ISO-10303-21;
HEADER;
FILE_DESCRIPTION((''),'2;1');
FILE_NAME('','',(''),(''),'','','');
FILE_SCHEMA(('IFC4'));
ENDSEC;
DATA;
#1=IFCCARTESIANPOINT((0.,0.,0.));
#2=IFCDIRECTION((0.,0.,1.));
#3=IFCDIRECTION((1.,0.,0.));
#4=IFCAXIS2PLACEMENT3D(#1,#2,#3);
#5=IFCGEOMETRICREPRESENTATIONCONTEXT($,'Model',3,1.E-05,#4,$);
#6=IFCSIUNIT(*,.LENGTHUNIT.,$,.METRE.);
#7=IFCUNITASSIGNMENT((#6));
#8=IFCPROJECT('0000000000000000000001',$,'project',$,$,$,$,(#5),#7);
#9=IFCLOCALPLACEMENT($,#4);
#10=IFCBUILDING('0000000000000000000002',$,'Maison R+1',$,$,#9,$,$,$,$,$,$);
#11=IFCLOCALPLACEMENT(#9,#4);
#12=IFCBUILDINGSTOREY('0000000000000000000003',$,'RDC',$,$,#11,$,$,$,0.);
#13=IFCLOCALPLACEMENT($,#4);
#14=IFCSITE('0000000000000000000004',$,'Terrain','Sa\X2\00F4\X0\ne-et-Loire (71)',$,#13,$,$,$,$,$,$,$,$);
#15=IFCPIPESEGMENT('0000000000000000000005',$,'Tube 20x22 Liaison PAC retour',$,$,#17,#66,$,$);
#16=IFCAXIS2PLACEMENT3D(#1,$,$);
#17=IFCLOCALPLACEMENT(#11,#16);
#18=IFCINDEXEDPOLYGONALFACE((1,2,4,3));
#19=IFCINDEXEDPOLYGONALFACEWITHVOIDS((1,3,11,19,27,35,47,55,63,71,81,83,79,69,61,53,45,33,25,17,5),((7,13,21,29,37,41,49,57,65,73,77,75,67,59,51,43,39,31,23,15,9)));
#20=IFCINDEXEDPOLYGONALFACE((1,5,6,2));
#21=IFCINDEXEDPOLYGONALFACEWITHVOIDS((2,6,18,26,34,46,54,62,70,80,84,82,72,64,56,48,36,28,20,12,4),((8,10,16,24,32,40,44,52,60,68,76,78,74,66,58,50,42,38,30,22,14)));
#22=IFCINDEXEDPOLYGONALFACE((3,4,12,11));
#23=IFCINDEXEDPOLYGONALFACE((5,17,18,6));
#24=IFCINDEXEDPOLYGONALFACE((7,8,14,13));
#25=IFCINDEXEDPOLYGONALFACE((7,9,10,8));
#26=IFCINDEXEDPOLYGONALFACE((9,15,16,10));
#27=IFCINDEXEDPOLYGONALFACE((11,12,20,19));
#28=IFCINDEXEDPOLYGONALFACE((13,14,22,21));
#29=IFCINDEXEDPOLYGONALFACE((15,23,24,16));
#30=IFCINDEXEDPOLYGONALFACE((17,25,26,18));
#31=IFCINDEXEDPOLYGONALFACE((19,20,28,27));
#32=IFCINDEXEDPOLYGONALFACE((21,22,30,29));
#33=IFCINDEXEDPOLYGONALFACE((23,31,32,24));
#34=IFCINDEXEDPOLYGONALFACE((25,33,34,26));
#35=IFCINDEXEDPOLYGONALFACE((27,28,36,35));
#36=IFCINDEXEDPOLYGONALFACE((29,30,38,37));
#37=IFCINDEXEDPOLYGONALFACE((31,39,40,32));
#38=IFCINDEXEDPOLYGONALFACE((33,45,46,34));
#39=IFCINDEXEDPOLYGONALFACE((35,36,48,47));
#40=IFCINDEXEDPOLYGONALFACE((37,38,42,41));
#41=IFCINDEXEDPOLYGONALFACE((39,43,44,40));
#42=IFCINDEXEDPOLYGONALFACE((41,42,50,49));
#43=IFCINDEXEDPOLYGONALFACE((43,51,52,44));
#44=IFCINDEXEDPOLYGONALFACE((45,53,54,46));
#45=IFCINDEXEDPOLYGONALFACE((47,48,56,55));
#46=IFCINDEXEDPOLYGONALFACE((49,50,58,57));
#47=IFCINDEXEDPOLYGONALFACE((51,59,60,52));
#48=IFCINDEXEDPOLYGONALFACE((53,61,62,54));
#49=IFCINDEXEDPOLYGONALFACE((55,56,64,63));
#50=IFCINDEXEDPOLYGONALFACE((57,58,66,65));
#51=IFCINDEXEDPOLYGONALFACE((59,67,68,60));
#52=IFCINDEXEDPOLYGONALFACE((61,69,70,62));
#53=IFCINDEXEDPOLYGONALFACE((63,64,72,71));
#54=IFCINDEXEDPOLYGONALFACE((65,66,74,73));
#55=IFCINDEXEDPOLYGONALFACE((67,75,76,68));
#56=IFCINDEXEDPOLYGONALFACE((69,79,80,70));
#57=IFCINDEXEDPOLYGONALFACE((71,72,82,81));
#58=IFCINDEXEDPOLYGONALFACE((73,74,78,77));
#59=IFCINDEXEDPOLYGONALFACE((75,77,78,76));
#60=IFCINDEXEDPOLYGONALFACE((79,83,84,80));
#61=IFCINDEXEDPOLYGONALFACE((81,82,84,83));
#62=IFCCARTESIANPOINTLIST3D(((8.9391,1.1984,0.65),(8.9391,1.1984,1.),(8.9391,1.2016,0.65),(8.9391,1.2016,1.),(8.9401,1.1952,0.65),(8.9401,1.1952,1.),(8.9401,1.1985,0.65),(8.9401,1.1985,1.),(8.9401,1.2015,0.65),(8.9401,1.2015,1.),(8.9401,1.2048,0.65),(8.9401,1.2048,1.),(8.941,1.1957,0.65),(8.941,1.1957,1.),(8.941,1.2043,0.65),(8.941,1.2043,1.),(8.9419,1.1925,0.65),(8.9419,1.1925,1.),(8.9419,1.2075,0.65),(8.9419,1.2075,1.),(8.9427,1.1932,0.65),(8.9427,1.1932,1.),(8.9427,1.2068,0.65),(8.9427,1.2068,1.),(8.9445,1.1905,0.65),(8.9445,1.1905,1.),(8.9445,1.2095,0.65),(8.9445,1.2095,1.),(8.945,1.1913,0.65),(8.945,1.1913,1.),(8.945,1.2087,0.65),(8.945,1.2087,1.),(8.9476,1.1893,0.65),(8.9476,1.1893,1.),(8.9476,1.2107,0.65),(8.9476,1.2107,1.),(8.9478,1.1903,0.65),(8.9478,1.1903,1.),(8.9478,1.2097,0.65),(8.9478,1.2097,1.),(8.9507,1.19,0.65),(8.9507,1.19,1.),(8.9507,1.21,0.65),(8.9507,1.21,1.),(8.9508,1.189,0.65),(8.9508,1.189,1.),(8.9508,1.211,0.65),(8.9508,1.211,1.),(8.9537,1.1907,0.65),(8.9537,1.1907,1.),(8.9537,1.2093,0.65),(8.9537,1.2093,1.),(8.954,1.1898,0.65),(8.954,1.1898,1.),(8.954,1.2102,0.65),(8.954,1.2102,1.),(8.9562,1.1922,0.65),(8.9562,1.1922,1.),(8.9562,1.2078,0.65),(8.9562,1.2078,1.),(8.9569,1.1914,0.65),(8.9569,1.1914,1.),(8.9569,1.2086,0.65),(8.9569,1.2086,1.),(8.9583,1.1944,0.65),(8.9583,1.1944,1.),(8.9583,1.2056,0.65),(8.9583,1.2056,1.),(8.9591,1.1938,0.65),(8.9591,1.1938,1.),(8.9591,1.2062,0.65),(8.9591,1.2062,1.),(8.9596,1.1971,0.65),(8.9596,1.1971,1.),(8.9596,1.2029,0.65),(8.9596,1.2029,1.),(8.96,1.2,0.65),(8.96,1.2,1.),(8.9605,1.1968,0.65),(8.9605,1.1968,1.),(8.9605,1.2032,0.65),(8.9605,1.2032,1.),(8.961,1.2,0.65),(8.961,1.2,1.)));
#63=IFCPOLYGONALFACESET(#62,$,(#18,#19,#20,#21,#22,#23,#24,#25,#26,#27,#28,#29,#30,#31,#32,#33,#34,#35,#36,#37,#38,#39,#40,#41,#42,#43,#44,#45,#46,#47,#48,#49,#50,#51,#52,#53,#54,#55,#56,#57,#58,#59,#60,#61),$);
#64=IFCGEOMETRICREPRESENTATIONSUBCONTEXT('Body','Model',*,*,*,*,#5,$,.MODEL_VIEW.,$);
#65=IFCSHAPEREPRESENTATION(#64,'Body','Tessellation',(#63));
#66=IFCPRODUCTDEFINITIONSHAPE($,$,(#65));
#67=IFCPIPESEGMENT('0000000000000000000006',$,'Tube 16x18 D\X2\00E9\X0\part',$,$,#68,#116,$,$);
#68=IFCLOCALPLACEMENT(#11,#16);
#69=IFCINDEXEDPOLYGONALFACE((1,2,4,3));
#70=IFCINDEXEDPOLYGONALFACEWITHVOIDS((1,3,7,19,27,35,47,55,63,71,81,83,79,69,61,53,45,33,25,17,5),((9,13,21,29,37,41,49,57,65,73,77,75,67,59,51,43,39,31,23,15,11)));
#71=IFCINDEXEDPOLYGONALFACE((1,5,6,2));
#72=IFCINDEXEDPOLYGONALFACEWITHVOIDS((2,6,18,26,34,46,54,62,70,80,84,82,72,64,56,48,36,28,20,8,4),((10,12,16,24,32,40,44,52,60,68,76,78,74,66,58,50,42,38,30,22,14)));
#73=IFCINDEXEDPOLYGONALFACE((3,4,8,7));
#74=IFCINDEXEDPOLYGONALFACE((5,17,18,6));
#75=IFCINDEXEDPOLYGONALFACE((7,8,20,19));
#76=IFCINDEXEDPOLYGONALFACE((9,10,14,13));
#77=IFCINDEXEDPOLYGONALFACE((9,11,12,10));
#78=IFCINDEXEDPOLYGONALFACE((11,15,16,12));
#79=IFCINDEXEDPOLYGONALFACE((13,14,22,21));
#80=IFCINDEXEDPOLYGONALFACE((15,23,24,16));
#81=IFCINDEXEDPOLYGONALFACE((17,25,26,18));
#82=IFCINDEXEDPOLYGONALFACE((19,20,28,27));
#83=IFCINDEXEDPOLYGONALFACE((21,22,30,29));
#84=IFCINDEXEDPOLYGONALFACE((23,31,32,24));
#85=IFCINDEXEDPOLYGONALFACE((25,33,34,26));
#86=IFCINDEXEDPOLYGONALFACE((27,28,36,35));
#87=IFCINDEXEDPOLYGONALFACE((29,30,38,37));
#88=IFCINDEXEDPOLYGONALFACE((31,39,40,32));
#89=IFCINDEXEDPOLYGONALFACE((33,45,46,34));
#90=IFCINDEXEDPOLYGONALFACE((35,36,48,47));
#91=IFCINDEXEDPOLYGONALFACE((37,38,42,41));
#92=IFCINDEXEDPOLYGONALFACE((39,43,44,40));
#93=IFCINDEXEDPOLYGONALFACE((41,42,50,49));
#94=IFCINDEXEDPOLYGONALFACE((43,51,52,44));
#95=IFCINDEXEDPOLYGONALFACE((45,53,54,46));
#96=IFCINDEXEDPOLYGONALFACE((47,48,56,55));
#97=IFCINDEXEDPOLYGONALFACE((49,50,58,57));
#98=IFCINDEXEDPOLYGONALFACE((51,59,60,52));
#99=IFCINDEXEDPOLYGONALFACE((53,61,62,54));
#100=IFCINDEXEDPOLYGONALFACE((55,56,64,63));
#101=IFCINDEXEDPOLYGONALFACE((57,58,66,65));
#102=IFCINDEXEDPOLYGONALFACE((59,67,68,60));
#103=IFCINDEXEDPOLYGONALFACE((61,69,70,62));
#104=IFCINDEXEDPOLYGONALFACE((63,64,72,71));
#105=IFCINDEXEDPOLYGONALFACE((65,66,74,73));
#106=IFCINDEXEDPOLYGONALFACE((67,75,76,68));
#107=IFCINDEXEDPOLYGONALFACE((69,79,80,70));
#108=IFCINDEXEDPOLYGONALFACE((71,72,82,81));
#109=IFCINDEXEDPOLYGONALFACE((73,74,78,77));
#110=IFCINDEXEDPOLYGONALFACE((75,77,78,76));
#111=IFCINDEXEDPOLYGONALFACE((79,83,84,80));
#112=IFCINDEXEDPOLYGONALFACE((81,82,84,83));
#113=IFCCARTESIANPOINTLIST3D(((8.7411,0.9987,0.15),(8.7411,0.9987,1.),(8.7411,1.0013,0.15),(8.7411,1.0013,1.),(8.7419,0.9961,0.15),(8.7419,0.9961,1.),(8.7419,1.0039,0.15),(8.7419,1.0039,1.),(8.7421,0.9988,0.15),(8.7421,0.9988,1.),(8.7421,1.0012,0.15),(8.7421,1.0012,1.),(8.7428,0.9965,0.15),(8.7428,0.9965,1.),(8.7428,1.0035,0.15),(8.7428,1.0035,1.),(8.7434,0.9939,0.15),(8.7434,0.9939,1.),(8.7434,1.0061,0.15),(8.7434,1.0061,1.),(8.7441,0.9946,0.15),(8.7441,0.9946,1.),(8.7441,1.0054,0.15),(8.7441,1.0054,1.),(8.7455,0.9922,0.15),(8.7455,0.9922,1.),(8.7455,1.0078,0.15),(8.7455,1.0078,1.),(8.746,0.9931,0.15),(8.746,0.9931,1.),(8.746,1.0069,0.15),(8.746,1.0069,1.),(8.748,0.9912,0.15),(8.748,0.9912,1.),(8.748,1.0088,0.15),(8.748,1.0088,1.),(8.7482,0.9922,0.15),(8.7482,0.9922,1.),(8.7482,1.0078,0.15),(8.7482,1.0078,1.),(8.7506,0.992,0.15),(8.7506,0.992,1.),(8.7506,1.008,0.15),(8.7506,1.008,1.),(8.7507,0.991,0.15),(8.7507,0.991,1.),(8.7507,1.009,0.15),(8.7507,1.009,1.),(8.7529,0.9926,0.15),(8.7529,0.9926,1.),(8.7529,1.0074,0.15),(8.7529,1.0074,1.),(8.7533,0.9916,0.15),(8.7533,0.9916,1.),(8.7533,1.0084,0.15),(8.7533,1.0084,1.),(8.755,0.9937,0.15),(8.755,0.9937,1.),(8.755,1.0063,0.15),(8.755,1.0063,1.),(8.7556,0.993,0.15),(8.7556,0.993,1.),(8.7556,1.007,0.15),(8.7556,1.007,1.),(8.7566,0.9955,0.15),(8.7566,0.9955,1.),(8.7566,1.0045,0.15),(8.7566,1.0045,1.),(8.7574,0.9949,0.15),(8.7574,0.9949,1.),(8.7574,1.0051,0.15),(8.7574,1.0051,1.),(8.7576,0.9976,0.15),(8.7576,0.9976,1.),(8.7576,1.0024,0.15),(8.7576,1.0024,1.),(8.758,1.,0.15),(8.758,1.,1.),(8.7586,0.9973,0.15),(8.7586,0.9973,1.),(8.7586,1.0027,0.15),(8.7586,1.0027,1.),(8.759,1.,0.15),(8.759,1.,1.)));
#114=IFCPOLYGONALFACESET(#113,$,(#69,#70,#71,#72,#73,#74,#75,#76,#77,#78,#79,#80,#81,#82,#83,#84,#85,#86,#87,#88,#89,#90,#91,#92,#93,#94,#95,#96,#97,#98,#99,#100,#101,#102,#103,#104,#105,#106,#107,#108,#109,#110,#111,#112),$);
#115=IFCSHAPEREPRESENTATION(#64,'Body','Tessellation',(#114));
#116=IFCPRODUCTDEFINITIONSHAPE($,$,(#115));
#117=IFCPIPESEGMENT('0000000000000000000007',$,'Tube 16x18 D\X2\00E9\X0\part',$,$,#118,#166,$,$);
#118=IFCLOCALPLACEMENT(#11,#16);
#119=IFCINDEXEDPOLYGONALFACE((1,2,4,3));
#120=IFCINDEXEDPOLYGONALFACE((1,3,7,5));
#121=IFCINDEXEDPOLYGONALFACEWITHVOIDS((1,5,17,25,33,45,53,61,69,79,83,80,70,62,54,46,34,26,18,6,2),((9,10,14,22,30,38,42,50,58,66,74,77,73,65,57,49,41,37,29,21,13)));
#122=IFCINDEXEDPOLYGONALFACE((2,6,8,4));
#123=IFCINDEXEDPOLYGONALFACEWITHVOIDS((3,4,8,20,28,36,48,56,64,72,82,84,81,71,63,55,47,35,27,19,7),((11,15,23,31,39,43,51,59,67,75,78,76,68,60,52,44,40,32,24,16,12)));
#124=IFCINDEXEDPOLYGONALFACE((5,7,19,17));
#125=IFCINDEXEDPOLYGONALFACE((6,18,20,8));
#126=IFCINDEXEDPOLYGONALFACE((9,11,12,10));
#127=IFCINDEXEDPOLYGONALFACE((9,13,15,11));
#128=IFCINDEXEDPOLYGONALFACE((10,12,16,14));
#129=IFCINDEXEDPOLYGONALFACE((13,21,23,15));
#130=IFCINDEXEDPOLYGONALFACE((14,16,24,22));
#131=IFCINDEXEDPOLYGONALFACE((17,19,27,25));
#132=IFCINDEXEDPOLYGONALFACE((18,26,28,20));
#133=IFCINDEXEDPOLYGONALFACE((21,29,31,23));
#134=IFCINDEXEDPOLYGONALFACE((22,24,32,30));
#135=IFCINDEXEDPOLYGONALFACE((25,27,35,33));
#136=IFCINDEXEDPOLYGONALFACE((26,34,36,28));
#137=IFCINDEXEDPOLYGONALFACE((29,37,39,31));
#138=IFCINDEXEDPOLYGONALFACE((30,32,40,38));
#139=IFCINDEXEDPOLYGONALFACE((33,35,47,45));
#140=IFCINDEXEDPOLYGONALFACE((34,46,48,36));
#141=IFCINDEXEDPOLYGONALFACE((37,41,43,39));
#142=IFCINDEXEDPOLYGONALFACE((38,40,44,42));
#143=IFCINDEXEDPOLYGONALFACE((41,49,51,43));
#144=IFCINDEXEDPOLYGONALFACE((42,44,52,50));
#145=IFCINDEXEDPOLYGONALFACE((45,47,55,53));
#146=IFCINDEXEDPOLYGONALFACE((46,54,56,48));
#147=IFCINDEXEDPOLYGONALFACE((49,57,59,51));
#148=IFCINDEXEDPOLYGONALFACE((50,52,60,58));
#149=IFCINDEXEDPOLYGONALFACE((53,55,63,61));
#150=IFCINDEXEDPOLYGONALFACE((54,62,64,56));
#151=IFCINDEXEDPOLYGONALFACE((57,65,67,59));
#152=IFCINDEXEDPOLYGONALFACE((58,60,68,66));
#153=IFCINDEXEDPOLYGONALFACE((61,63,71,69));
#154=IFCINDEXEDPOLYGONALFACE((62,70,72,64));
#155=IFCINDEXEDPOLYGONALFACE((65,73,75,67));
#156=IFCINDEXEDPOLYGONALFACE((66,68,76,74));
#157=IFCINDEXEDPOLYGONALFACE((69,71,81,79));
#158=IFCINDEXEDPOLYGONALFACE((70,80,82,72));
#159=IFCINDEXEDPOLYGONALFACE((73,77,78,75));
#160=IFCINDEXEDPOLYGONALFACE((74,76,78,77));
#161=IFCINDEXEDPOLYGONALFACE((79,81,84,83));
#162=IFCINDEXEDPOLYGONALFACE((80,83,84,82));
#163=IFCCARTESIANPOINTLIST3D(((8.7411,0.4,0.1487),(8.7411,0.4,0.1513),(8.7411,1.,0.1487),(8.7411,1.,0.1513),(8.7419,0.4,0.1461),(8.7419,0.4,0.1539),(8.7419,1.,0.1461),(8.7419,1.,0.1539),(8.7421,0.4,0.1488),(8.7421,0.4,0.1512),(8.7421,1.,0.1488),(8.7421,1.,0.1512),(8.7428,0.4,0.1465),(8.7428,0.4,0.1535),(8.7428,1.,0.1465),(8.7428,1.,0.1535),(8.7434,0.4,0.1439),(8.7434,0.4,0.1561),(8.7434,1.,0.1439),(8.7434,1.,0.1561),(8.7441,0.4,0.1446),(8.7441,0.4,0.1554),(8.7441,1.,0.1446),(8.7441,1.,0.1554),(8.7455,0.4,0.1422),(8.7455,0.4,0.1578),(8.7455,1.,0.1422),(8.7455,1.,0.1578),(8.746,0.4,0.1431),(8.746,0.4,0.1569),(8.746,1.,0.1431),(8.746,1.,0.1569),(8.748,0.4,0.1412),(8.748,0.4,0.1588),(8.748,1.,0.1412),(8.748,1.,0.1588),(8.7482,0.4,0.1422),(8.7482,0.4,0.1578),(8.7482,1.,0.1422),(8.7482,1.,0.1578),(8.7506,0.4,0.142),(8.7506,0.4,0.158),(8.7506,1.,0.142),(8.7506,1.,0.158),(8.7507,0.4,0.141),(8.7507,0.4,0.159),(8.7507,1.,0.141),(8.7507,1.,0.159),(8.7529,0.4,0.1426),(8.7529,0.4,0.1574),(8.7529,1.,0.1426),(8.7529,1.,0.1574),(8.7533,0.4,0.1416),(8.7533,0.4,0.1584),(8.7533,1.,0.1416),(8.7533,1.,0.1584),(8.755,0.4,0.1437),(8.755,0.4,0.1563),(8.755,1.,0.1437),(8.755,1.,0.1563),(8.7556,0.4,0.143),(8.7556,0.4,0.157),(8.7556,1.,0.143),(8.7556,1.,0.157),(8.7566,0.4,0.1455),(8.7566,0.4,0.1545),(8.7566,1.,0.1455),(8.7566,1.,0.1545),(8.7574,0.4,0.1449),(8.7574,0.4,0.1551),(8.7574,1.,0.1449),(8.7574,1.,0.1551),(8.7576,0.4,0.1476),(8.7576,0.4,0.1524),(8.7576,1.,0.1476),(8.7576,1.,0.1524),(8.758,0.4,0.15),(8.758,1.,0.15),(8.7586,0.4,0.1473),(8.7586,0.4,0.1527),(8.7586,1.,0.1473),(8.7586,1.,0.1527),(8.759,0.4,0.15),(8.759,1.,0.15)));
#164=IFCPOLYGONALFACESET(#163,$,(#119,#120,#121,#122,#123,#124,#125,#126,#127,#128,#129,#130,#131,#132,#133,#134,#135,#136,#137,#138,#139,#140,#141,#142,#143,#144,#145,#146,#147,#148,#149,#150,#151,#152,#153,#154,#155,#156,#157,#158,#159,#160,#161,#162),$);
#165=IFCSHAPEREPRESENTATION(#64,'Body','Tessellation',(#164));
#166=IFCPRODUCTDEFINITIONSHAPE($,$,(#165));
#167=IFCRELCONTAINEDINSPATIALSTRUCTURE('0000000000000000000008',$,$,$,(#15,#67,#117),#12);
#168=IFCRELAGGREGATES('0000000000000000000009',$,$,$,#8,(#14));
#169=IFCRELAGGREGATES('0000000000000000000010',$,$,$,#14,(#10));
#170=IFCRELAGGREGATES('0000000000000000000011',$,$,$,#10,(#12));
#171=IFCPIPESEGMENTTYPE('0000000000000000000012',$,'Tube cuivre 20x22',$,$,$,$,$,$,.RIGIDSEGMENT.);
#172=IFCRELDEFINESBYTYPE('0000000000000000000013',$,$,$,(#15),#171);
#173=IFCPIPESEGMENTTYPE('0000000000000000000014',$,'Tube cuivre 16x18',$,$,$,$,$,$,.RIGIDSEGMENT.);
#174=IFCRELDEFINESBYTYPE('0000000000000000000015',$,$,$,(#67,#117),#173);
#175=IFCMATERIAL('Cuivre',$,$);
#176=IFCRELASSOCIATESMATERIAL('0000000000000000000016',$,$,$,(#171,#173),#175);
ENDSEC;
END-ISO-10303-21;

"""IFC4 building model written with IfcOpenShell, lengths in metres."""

from ifc_helpers import new_model, si_unit, frame, origin_with_axes, place, context, subcontext, project, spatial, hollow_circle, extrude, material, type_object, element, save


model = new_model("IFC4")

# Units and contexts
model_context = context("Model", 3, precision=1e-05, world=origin_with_axes())
body_context = subcontext(model_context, "Body", "Model", "MODEL_VIEW")
ifc_project = project(units=[si_unit("LENGTHUNIT", "METRE")], contexts=[model_context])

# Site, building, storey
site_placement = place(None, origin_with_axes())
site = spatial("IfcSite", under=ifc_project, at=site_placement, Name="Terrain", Description="Saône-et-Loire (71)")
building_placement = place(None, origin_with_axes())
building = spatial("IfcBuilding", under=site, at=building_placement, Name="Maison R+1")
storey_placement = place(building_placement, origin_with_axes())
storey = spatial("IfcBuildingStorey", under=building, at=storey_placement, Name="RDC", Elevation=0.0)

# Pipe segments
ifc_material_1 = material(Name="Cuivre")
pipe_segment_type_1 = type_object("IfcPipeSegmentType", Name="Tube cuivre 20x22", PredefinedType="RIGIDSEGMENT", material=ifc_material_1)
pipe_segment_1_placement = place(storey_placement, frame((8.95, 1.2, 0.65), z_axis=(0.0, 0.0, 1.0), x_axis=(1.0, 0.0, 0.0)))
element("IfcPipeSegment", 1, at=pipe_segment_1_placement, inside=storey, type_object=pipe_segment_type_1, Name="Tube 20x22 Liaison PAC retour", context=body_context, shape_type="SweptSolid", body=[
    extrude(hollow_circle(Radius=0.011, WallThickness=0.001), origin_with_axes(), (0.0, 0.0, 1.0), 0.35),
])
pipe_segment_type_2 = type_object("IfcPipeSegmentType", Name="Tube cuivre 16x18", PredefinedType="RIGIDSEGMENT", material=ifc_material_1)
pipe_segment_2_placement = place(storey_placement, frame((8.75, 1.0, 1.0), z_axis=(0.0, 0.0, -1.0), x_axis=(1.0, 0.0, 0.0)))
element("IfcPipeSegment", 2, at=pipe_segment_2_placement, inside=storey, type_object=pipe_segment_type_2, Name="Tube 16x18 Départ", context=body_context, shape_type="SweptSolid", body=[
    extrude(hollow_circle(Radius=0.009, WallThickness=0.001), origin_with_axes(), (0.0, 0.0, 1.0), 0.85),
])
pipe_segment_3_placement = place(storey_placement, frame((8.75, 1.0, 0.15), z_axis=(0.0, -1.0, 0.0), x_axis=(1.0, 0.0, 0.0)))
element("IfcPipeSegment", 3, at=pipe_segment_3_placement, inside=storey, type_object=pipe_segment_type_2, Name="Tube 16x18 Départ", context=body_context, shape_type="SweptSolid", body=[
    extrude(hollow_circle(Radius=0.009, WallThickness=0.001), origin_with_axes(), (0.0, 0.0, 1.0), 0.6),
])

save(model, "model.ifc")
